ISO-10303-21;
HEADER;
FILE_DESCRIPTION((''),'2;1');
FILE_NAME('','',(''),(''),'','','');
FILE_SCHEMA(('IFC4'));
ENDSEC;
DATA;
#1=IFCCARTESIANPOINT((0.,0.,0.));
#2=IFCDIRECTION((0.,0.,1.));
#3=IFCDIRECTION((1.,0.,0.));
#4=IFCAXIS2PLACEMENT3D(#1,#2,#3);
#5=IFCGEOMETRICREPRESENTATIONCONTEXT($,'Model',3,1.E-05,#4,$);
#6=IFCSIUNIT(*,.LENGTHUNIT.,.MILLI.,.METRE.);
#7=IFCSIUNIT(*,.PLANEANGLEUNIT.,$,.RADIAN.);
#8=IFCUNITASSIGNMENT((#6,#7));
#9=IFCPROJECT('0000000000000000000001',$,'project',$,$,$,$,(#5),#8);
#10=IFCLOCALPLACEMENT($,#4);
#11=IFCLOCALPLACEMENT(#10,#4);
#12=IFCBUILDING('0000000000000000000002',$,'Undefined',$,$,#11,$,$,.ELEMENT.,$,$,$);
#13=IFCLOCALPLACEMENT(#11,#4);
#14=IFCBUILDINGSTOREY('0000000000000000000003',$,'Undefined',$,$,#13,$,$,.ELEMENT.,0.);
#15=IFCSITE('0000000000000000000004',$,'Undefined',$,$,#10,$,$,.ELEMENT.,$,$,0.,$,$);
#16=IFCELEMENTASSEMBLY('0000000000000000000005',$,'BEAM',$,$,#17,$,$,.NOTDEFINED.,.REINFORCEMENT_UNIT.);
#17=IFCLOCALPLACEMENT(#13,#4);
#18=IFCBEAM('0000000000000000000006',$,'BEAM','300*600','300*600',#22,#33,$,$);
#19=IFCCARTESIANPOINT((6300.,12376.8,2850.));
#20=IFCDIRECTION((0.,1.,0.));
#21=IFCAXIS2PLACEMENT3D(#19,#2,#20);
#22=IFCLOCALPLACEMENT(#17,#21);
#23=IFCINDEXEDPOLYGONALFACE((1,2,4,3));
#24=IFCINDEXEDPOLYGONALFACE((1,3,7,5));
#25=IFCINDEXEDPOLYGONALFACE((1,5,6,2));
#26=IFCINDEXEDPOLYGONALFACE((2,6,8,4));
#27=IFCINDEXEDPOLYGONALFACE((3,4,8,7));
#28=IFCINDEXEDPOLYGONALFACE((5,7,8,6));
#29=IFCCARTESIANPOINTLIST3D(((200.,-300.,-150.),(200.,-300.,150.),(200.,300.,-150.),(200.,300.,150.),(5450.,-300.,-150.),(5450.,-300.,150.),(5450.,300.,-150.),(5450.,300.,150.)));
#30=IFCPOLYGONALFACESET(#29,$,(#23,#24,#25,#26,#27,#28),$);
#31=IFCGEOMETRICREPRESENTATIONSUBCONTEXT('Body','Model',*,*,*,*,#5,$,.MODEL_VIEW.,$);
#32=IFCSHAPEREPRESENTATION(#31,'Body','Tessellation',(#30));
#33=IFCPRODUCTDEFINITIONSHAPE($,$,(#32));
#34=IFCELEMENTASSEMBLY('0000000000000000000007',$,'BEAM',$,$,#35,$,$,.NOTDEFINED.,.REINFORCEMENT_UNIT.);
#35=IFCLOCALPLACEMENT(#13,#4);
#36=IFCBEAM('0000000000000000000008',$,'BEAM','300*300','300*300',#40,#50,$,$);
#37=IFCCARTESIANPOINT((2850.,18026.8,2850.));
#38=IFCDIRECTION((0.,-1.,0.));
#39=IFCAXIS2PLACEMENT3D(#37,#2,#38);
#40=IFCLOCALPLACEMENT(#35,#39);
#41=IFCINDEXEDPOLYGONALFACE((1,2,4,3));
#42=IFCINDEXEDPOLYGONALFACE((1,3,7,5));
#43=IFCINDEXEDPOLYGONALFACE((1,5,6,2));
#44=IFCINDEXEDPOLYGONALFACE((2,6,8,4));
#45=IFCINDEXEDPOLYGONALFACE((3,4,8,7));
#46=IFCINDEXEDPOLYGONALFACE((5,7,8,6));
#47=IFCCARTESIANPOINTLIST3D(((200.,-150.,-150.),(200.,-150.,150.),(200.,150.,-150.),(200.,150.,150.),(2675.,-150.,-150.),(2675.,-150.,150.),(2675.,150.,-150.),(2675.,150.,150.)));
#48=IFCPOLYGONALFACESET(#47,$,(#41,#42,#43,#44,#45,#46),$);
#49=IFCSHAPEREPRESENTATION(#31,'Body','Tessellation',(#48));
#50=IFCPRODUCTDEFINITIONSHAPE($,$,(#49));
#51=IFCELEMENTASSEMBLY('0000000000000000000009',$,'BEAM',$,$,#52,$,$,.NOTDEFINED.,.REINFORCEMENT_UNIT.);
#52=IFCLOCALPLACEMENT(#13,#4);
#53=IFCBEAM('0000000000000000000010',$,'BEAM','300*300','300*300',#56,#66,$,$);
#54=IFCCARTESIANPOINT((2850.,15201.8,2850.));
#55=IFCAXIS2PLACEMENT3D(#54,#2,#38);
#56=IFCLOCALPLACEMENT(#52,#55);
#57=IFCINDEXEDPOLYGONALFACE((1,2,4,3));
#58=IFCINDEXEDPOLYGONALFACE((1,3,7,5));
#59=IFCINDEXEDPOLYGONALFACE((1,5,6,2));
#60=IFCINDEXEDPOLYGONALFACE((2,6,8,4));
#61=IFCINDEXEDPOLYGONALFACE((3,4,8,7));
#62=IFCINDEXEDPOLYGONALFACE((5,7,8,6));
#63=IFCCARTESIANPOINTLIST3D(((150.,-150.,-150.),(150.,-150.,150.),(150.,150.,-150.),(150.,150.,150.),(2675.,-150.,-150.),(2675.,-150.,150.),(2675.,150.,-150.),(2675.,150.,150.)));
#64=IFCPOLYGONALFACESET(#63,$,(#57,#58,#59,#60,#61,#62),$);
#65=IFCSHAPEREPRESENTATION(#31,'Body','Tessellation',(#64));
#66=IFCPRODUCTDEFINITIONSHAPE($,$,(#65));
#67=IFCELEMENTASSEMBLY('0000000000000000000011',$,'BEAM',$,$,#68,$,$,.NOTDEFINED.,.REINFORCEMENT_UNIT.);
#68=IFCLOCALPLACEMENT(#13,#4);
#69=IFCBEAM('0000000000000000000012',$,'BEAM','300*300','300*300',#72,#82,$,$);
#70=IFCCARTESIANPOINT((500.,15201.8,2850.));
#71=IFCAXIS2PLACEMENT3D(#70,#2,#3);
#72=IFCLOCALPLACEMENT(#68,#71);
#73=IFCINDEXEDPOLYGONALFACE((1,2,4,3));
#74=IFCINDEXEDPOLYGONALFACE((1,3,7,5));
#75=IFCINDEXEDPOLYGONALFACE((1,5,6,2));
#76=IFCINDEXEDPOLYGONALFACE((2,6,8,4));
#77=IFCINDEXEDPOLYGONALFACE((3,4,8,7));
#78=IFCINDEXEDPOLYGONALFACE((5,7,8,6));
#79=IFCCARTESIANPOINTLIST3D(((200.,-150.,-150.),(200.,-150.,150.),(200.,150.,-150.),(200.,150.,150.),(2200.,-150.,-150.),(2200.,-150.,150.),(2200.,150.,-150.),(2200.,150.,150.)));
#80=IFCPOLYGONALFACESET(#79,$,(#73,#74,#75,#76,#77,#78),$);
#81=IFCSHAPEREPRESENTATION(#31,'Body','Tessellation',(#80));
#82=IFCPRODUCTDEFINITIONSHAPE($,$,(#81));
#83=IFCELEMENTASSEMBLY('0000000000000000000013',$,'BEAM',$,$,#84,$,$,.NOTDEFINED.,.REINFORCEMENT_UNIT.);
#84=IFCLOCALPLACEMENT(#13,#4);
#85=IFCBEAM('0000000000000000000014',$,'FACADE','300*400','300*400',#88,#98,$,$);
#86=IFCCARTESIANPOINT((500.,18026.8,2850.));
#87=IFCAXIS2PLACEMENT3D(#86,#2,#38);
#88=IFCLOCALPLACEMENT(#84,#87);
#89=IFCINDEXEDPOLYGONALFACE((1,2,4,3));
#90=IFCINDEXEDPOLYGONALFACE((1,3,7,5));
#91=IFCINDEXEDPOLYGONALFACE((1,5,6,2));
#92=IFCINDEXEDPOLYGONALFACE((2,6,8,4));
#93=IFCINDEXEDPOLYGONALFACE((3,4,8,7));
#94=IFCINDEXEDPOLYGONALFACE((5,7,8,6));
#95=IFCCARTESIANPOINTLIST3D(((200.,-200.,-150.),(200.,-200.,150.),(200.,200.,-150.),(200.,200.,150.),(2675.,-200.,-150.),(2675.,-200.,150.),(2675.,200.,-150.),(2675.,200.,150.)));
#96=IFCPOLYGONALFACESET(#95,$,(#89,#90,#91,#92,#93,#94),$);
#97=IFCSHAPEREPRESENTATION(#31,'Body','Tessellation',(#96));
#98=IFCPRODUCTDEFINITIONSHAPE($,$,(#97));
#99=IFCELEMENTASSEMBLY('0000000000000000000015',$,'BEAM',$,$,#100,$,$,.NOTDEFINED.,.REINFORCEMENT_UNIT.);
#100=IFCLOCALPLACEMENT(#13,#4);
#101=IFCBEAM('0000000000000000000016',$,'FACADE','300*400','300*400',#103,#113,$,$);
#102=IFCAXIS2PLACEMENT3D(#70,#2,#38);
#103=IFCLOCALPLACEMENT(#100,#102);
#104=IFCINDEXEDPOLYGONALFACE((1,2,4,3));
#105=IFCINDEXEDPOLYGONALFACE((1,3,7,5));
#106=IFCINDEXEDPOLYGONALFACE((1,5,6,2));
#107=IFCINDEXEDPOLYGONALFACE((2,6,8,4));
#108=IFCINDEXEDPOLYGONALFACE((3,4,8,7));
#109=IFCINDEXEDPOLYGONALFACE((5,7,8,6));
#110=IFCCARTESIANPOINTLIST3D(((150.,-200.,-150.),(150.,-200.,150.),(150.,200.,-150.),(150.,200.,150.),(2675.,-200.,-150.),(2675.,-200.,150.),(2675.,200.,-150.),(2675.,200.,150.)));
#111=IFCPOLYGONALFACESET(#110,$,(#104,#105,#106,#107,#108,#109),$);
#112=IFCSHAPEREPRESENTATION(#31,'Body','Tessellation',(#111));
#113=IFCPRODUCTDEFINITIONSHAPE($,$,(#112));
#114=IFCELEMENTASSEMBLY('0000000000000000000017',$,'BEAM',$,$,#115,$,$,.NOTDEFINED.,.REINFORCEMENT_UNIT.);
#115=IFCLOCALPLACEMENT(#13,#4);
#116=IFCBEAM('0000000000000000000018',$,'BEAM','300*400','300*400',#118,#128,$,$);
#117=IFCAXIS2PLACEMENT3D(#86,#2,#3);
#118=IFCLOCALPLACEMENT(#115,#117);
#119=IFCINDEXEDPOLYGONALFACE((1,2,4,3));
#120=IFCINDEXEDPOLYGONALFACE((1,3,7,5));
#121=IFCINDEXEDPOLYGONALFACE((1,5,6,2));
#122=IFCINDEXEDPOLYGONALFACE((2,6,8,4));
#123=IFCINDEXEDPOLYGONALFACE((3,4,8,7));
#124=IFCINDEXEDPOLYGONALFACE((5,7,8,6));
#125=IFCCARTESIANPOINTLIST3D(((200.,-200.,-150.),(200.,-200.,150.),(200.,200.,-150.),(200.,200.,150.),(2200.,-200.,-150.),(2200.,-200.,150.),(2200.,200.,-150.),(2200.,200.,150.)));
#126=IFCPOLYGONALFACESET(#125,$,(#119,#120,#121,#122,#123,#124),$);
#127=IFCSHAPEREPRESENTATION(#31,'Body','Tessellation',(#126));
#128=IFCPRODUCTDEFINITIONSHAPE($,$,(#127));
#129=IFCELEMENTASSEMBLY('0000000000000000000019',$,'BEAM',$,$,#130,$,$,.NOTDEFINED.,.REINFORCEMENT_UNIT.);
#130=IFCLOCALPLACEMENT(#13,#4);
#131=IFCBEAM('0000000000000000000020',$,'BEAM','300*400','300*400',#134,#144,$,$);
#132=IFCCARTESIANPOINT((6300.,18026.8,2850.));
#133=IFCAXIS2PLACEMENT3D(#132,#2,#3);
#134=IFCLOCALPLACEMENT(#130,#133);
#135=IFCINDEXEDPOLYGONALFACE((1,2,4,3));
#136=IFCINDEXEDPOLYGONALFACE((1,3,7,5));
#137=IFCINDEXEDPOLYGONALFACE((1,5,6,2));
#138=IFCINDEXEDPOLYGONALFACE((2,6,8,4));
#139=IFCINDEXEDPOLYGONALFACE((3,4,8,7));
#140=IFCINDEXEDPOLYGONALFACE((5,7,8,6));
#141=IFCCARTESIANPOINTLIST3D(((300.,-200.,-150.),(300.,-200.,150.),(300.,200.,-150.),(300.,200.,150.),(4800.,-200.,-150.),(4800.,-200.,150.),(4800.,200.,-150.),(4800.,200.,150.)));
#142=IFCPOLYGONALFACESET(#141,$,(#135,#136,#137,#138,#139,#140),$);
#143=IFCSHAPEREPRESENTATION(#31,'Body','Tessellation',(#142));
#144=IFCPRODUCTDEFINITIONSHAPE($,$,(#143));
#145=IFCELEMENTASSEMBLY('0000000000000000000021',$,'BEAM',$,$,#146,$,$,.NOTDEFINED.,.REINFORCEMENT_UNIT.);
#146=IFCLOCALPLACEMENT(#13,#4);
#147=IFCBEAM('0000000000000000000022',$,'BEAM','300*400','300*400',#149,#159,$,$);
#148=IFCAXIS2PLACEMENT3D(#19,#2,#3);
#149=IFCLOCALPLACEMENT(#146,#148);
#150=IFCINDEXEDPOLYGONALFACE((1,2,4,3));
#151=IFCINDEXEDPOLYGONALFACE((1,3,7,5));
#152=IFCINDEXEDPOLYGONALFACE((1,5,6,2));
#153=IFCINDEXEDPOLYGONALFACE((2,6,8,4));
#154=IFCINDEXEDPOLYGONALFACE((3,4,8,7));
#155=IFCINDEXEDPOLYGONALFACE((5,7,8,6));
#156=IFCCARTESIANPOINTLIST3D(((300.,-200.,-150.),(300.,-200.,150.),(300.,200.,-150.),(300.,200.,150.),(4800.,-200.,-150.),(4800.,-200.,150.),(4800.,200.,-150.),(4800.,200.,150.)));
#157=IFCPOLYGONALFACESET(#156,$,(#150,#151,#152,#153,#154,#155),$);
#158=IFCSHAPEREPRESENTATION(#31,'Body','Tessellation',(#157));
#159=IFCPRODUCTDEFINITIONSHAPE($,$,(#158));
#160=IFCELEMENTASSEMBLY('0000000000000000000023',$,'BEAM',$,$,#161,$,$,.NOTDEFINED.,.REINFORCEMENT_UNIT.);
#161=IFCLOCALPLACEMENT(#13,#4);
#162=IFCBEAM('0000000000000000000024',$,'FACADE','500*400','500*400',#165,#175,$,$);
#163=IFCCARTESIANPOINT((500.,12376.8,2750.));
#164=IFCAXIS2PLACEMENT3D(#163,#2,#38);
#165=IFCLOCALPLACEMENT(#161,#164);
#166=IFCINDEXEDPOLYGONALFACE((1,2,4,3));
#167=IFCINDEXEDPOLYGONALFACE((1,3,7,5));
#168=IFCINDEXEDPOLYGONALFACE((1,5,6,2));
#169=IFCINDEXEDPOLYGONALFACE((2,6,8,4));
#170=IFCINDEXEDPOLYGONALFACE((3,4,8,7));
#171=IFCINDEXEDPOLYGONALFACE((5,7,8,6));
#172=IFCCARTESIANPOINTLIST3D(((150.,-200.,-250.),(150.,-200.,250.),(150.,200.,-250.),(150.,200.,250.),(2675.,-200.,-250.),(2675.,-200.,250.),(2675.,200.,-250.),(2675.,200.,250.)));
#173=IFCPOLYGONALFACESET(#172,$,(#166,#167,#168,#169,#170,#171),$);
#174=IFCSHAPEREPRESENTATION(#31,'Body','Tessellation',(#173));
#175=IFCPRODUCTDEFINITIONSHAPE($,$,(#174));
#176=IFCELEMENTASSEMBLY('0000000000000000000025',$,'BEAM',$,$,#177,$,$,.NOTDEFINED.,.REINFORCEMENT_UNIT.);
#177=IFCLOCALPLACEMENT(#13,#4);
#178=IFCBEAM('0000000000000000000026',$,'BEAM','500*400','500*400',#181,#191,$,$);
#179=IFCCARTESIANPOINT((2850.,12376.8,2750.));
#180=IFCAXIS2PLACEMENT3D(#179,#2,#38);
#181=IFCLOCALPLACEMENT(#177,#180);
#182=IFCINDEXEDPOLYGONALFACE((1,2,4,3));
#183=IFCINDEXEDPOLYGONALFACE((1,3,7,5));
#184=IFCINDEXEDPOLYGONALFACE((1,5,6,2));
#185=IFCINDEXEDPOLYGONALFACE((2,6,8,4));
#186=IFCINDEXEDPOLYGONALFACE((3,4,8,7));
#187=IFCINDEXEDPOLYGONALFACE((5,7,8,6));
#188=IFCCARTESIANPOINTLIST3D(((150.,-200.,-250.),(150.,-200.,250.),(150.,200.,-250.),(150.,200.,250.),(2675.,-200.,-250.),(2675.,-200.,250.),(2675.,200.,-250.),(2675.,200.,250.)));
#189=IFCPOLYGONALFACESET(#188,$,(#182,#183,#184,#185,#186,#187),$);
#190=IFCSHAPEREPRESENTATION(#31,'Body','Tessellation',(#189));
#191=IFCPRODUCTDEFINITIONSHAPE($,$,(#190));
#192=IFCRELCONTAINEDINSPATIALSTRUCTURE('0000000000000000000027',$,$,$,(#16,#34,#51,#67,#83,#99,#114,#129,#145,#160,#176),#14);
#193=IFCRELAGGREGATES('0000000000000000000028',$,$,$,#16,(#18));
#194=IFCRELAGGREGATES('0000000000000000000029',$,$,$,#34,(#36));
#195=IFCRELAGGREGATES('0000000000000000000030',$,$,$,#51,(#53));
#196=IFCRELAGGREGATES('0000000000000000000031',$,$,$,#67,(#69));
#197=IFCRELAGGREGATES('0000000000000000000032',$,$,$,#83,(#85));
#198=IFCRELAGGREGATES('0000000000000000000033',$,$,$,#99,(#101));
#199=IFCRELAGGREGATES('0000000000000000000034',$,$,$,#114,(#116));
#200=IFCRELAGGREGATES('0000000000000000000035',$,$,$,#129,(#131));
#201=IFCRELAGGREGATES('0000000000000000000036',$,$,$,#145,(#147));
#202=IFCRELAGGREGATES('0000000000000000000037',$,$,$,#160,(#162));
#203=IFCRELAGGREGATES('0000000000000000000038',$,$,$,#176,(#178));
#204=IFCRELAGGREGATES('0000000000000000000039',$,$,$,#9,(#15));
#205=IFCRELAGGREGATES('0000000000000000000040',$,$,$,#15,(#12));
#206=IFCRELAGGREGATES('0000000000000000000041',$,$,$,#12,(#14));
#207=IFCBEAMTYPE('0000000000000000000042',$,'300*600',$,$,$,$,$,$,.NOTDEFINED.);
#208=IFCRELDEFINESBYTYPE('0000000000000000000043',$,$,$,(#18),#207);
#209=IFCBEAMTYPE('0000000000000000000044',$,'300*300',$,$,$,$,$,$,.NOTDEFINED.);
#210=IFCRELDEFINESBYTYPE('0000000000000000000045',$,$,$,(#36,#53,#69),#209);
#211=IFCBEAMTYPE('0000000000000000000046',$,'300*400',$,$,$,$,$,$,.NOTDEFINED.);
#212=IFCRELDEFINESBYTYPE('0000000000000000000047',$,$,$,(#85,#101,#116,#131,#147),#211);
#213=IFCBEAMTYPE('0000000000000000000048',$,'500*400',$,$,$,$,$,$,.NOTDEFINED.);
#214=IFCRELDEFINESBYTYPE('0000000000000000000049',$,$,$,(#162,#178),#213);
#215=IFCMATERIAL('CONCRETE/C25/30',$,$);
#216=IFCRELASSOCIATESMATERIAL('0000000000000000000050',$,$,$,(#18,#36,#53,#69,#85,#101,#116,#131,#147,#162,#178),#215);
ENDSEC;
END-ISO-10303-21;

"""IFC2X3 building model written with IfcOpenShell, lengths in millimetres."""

from ifc_helpers import new_model, si_unit, frame, origin_with_axes, origin_2d_with_axis, place, context, subcontext, project, spatial, rectangle, extrude, material, type_object, element, aggregate, save


model = new_model("IFC2X3")

# Units and contexts
model_context = context("Model", 3, precision=1e-05, world=origin_with_axes())
body_context = subcontext(model_context, "Body", "Model", "MODEL_VIEW")
ifc_project = project(units=[si_unit("LENGTHUNIT", "METRE", prefix="MILLI"), si_unit("PLANEANGLEUNIT", "RADIAN")], contexts=[model_context])

# Site, building, storey
site_placement = place(None, origin_with_axes())
site = spatial("IfcSite", under=ifc_project, at=site_placement, Name="Undefined", CompositionType="ELEMENT", RefElevation=0.0)
building_placement = place(site_placement, origin_with_axes())
building = spatial("IfcBuilding", under=site, at=building_placement, Name="Undefined", CompositionType="ELEMENT")
storey_placement = place(building_placement, origin_with_axes())
storey = spatial("IfcBuildingStorey", under=building, at=storey_placement, Name="Undefined", CompositionType="ELEMENT", Elevation=0.0)

# Shared definitions
ifc_material = material(Name="CONCRETE/C25/30")

# Element assemblies, beams
assembly_1_placement = place(storey_placement, origin_with_axes())
assembly_1 = element("IfcElementAssembly", 1, at=assembly_1_placement, inside=storey, Name="BEAM", AssemblyPlace="NOTDEFINED", PredefinedType="REINFORCEMENT_UNIT")
beam_type_1 = type_object("IfcBeamType", Name="300*600", PredefinedType="NOTDEFINED")
beam_1_placement = place(assembly_1_placement, frame((6300.0, 12376.8, 2850.0), z_axis=(0.0, 0.0, 1.0), x_axis=(0.0, 1.0, 0.0)))
beam_1 = element("IfcBeam", 2, at=beam_1_placement, type_object=beam_type_1, material=ifc_material, Name="BEAM", Description="300*600", ObjectType="300*600", context=body_context, shape_type="SweptSolid", body=[
    extrude(rectangle(XDim=600.0, YDim=300.0, at=origin_2d_with_axis()), frame((5450.0, 0.0, 0.0), z_axis=(-1.0, 0.0, 0.0), x_axis=(0.0, -1.0, 0.0)), (0.0, 0.0, 1.0), 5250.0),
])
aggregate(assembly_1, [beam_1])
assembly_2_placement = place(storey_placement, origin_with_axes())
assembly_2 = element("IfcElementAssembly", 3, at=assembly_2_placement, inside=storey, Name="BEAM", AssemblyPlace="NOTDEFINED", PredefinedType="REINFORCEMENT_UNIT")
beam_type_2 = type_object("IfcBeamType", Name="300*300", PredefinedType="NOTDEFINED")
beam_2_placement = place(assembly_2_placement, frame((2850.0, 18026.8, 2850.0), z_axis=(0.0, 0.0, 1.0), x_axis=(0.0, -1.0, 0.0)))
beam_2 = element("IfcBeam", 4, at=beam_2_placement, type_object=beam_type_2, material=ifc_material, Name="BEAM", Description="300*300", ObjectType="300*300", context=body_context, shape_type="SweptSolid", body=[
    extrude(rectangle(XDim=300.0, YDim=300.0, at=origin_2d_with_axis()), frame((2675.0, 0.0, 0.0), z_axis=(-1.0, 0.0, 0.0), x_axis=(0.0, -1.0, 0.0)), (0.0, 0.0, 1.0), 2475.0),
])
aggregate(assembly_2, [beam_2])
assembly_3_placement = place(storey_placement, origin_with_axes())
assembly_3 = element("IfcElementAssembly", 5, at=assembly_3_placement, inside=storey, Name="BEAM", AssemblyPlace="NOTDEFINED", PredefinedType="REINFORCEMENT_UNIT")
beam_3_placement = place(assembly_3_placement, frame((2850.0, 15201.8, 2850.0), z_axis=(0.0, 0.0, 1.0), x_axis=(0.0, -1.0, 0.0)))
beam_3 = element("IfcBeam", 6, at=beam_3_placement, type_object=beam_type_2, material=ifc_material, Name="BEAM", Description="300*300", ObjectType="300*300", context=body_context, shape_type="SweptSolid", body=[
    extrude(rectangle(XDim=300.0, YDim=300.0, at=origin_2d_with_axis()), frame((2675.0, 0.0, 0.0), z_axis=(-1.0, 0.0, 0.0), x_axis=(0.0, -1.0, 0.0)), (0.0, 0.0, 1.0), 2525.0),
])
aggregate(assembly_3, [beam_3])
assembly_4_placement = place(storey_placement, origin_with_axes())
assembly_4 = element("IfcElementAssembly", 7, at=assembly_4_placement, inside=storey, Name="BEAM", AssemblyPlace="NOTDEFINED", PredefinedType="REINFORCEMENT_UNIT")
beam_4_placement = place(assembly_4_placement, frame((500.0, 15201.8, 2850.0), z_axis=(0.0, 0.0, 1.0), x_axis=(1.0, 0.0, 0.0)))
beam_4 = element("IfcBeam", 8, at=beam_4_placement, type_object=beam_type_2, material=ifc_material, Name="BEAM", Description="300*300", ObjectType="300*300", context=body_context, shape_type="SweptSolid", body=[
    extrude(rectangle(XDim=300.0, YDim=300.0, at=origin_2d_with_axis()), frame((2200.0, 0.0, 0.0), z_axis=(-1.0, 0.0, 0.0), x_axis=(0.0, -1.0, 0.0)), (0.0, 0.0, 1.0), 2000.0),
])
aggregate(assembly_4, [beam_4])
assembly_5_placement = place(storey_placement, origin_with_axes())
assembly_5 = element("IfcElementAssembly", 9, at=assembly_5_placement, inside=storey, Name="BEAM", AssemblyPlace="NOTDEFINED", PredefinedType="REINFORCEMENT_UNIT")
beam_type_3 = type_object("IfcBeamType", Name="300*400", PredefinedType="NOTDEFINED")
beam_5_placement = place(assembly_5_placement, frame((500.0, 18026.8, 2850.0), z_axis=(0.0, 0.0, 1.0), x_axis=(0.0, -1.0, 0.0)))
beam_5 = element("IfcBeam", 10, at=beam_5_placement, type_object=beam_type_3, material=ifc_material, Name="FACADE", Description="300*400", ObjectType="300*400", context=body_context, shape_type="SweptSolid", body=[
    extrude(rectangle(XDim=400.0, YDim=300.0, at=origin_2d_with_axis()), frame((2675.0, 0.0, 0.0), z_axis=(-1.0, 0.0, 0.0), x_axis=(0.0, -1.0, 0.0)), (0.0, 0.0, 1.0), 2475.0),
])
aggregate(assembly_5, [beam_5])
assembly_6_placement = place(storey_placement, origin_with_axes())
assembly_6 = element("IfcElementAssembly", 11, at=assembly_6_placement, inside=storey, Name="BEAM", AssemblyPlace="NOTDEFINED", PredefinedType="REINFORCEMENT_UNIT")
beam_6_placement = place(assembly_6_placement, frame((500.0, 15201.8, 2850.0), z_axis=(0.0, 0.0, 1.0), x_axis=(0.0, -1.0, 0.0)))
beam_6 = element("IfcBeam", 12, at=beam_6_placement, type_object=beam_type_3, material=ifc_material, Name="FACADE", Description="300*400", ObjectType="300*400", context=body_context, shape_type="SweptSolid", body=[
    extrude(rectangle(XDim=400.0, YDim=300.0, at=origin_2d_with_axis()), frame((2675.0, 0.0, 0.0), z_axis=(-1.0, 0.0, 0.0), x_axis=(0.0, -1.0, 0.0)), (0.0, 0.0, 1.0), 2525.0),
])
aggregate(assembly_6, [beam_6])
assembly_7_placement = place(storey_placement, origin_with_axes())
assembly_7 = element("IfcElementAssembly", 13, at=assembly_7_placement, inside=storey, Name="BEAM", AssemblyPlace="NOTDEFINED", PredefinedType="REINFORCEMENT_UNIT")
beam_7_placement = place(assembly_7_placement, frame((500.0, 18026.8, 2850.0), z_axis=(0.0, 0.0, 1.0), x_axis=(1.0, 0.0, 0.0)))
beam_7 = element("IfcBeam", 14, at=beam_7_placement, type_object=beam_type_3, material=ifc_material, Name="BEAM", Description="300*400", ObjectType="300*400", context=body_context, shape_type="SweptSolid", body=[
    extrude(rectangle(XDim=400.0, YDim=300.0, at=origin_2d_with_axis()), frame((2200.0, 0.0, 0.0), z_axis=(-1.0, 0.0, 0.0), x_axis=(0.0, -1.0, 0.0)), (0.0, 0.0, 1.0), 2000.0),
])
aggregate(assembly_7, [beam_7])
assembly_8_placement = place(storey_placement, origin_with_axes())
assembly_8 = element("IfcElementAssembly", 15, at=assembly_8_placement, inside=storey, Name="BEAM", AssemblyPlace="NOTDEFINED", PredefinedType="REINFORCEMENT_UNIT")
beam_8_placement = place(assembly_8_placement, frame((6300.0, 18026.8, 2850.0), z_axis=(0.0, 0.0, 1.0), x_axis=(1.0, 0.0, 0.0)))
beam_8 = element("IfcBeam", 16, at=beam_8_placement, type_object=beam_type_3, material=ifc_material, Name="BEAM", Description="300*400", ObjectType="300*400", context=body_context, shape_type="SweptSolid", body=[
    extrude(rectangle(XDim=400.0, YDim=300.0, at=origin_2d_with_axis()), frame((4800.0, 0.0, 0.0), z_axis=(-1.0, 0.0, 0.0), x_axis=(0.0, -1.0, 0.0)), (0.0, 0.0, 1.0), 4500.0),
])
aggregate(assembly_8, [beam_8])
assembly_9_placement = place(storey_placement, origin_with_axes())
assembly_9 = element("IfcElementAssembly", 17, at=assembly_9_placement, inside=storey, Name="BEAM", AssemblyPlace="NOTDEFINED", PredefinedType="REINFORCEMENT_UNIT")
beam_9_placement = place(assembly_9_placement, frame((6300.0, 12376.8, 2850.0), z_axis=(0.0, 0.0, 1.0), x_axis=(1.0, 0.0, 0.0)))
beam_9 = element("IfcBeam", 18, at=beam_9_placement, type_object=beam_type_3, material=ifc_material, Name="BEAM", Description="300*400", ObjectType="300*400", context=body_context, shape_type="SweptSolid", body=[
    extrude(rectangle(XDim=400.0, YDim=300.0, at=origin_2d_with_axis()), frame((4800.0, 0.0, 0.0), z_axis=(-1.0, 0.0, 0.0), x_axis=(0.0, -1.0, 0.0)), (0.0, 0.0, 1.0), 4500.0),
])
aggregate(assembly_9, [beam_9])
assembly_10_placement = place(storey_placement, origin_with_axes())
assembly_10 = element("IfcElementAssembly", 19, at=assembly_10_placement, inside=storey, Name="BEAM", AssemblyPlace="NOTDEFINED", PredefinedType="REINFORCEMENT_UNIT")
beam_type_4 = type_object("IfcBeamType", Name="500*400", PredefinedType="NOTDEFINED")
beam_10_placement = place(assembly_10_placement, frame((500.0, 12376.8, 2750.0), z_axis=(0.0, 0.0, 1.0), x_axis=(0.0, -1.0, 0.0)))
beam_10 = element("IfcBeam", 20, at=beam_10_placement, type_object=beam_type_4, material=ifc_material, Name="FACADE", Description="500*400", ObjectType="500*400", context=body_context, shape_type="SweptSolid", body=[
    extrude(rectangle(XDim=400.0, YDim=500.0, at=origin_2d_with_axis()), frame((2675.0, 0.0, 0.0), z_axis=(-1.0, 0.0, 0.0), x_axis=(0.0, -1.0, 0.0)), (0.0, 0.0, 1.0), 2525.0),
])
aggregate(assembly_10, [beam_10])
assembly_11_placement = place(storey_placement, origin_with_axes())
assembly_11 = element("IfcElementAssembly", 21, at=assembly_11_placement, inside=storey, Name="BEAM", AssemblyPlace="NOTDEFINED", PredefinedType="REINFORCEMENT_UNIT")
beam_11_placement = place(assembly_11_placement, frame((2850.0, 12376.8, 2750.0), z_axis=(0.0, 0.0, 1.0), x_axis=(0.0, -1.0, 0.0)))
beam_11 = element("IfcBeam", 22, at=beam_11_placement, type_object=beam_type_4, material=ifc_material, Name="BEAM", Description="500*400", ObjectType="500*400", context=body_context, shape_type="SweptSolid", body=[
    extrude(rectangle(XDim=400.0, YDim=500.0, at=origin_2d_with_axis()), frame((2675.0, 0.0, 0.0), z_axis=(-1.0, 0.0, 0.0), x_axis=(0.0, -1.0, 0.0)), (0.0, 0.0, 1.0), 2525.0),
])
aggregate(assembly_11, [beam_11])

save(model, "model.ifc")
